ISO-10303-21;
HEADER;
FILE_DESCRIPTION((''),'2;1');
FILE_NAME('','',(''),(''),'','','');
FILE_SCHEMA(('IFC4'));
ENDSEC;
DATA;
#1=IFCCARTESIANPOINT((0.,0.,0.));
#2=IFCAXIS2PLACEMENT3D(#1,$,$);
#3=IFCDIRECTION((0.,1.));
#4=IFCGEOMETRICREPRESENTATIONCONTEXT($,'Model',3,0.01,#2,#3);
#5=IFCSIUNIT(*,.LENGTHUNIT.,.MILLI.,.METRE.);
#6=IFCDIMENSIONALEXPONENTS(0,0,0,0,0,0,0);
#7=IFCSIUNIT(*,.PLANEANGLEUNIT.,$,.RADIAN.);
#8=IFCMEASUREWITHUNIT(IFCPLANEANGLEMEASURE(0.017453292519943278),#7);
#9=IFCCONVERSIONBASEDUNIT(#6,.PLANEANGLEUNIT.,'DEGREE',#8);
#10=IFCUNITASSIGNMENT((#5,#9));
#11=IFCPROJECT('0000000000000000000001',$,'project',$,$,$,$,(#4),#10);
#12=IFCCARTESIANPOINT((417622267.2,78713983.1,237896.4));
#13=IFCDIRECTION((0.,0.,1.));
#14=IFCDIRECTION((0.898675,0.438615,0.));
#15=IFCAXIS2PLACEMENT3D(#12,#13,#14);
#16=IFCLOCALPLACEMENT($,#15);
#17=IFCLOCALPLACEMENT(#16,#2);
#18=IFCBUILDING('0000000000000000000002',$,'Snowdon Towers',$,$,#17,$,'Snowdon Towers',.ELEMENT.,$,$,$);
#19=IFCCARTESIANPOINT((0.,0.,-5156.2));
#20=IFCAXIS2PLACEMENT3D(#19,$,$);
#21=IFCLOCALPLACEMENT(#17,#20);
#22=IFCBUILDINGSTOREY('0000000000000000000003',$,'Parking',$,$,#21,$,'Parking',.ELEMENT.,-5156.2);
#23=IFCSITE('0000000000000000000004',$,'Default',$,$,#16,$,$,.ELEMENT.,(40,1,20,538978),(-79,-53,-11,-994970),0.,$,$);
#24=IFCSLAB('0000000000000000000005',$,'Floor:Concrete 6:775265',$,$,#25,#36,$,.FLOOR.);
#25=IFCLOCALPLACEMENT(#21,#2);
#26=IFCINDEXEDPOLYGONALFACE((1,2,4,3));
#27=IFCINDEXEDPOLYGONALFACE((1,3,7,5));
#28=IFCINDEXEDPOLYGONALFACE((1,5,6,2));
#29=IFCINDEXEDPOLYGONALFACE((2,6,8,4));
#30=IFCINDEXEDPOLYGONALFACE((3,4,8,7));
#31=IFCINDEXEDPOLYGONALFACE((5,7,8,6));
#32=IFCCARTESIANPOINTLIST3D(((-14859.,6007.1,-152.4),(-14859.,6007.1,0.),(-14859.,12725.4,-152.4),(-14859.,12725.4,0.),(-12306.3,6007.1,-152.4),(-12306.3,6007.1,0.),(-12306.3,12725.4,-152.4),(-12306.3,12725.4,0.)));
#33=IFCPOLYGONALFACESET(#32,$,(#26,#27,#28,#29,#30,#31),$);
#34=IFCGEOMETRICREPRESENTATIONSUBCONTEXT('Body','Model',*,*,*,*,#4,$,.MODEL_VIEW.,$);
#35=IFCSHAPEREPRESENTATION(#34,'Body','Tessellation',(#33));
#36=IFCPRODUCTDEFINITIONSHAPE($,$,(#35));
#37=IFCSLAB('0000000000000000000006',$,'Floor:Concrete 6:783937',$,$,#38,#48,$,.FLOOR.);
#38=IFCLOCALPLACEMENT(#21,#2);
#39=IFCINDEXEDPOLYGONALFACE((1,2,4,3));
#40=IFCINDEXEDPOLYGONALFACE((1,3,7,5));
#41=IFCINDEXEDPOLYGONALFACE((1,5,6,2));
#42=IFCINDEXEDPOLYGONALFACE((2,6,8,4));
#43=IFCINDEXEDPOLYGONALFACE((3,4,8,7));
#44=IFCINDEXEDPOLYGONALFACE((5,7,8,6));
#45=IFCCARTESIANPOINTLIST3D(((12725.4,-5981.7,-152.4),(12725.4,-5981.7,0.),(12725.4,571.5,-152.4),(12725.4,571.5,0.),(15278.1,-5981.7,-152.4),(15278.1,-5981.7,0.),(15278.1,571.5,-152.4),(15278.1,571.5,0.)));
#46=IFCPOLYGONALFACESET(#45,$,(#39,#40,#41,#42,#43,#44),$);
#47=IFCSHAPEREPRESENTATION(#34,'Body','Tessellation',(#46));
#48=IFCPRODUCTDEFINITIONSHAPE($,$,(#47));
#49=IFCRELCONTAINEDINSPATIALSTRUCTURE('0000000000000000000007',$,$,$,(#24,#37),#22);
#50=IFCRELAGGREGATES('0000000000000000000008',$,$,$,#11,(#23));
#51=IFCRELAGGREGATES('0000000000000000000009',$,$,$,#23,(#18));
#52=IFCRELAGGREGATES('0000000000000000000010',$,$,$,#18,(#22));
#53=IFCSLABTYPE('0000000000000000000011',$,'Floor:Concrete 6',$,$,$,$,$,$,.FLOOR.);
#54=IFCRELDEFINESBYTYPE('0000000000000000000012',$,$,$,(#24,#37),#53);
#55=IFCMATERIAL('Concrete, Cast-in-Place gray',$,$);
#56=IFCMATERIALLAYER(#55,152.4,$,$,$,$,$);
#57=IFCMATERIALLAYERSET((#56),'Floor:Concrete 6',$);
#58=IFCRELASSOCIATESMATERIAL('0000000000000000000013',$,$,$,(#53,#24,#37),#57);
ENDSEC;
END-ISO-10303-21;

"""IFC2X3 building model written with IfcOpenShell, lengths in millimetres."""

from ifc_helpers import new_model, entity, si_unit, converted_unit, direction, frame, frame_2d, origin, origin_2d_with_axis, place, context, subcontext, project, spatial, rectangle, extrude, material, layer, layer_set, layer_usage, type_object, element, save


model = new_model("IFC2X3")

# Units and contexts
model_context = context("Model", 3, precision=0.01, world=origin(), true_north=direction((0.0, 1.0)))
body_context = subcontext(model_context, "Body", "Model", "MODEL_VIEW")
ifc_project = project(units=[si_unit("LENGTHUNIT", "METRE", prefix="MILLI"), converted_unit("PLANEANGLEUNIT", "DEGREE", entity("IfcPlaneAngleMeasure", 0.017453292519943278), si_unit("PLANEANGLEUNIT", "RADIAN"), dimensions=[0, 0, 0, 0, 0, 0, 0])], contexts=[model_context])

# Site, building, storey
site_placement = place(None, frame((417622267.2, 78713983.1, 237896.4), z_axis=(0.0, 0.0, 1.0), x_axis=(0.898675, 0.438615, 0.0)))
site = spatial("IfcSite", under=ifc_project, at=site_placement, Name="Default", CompositionType="ELEMENT", RefLatitude=(40, 1, 20, 538978), RefLongitude=(-79, -53, -11, -994970), RefElevation=0.0)
building_placement = place(site_placement, origin())
building = spatial("IfcBuilding", under=site, at=building_placement, Name="Snowdon Towers", LongName="Snowdon Towers", CompositionType="ELEMENT")
storey_placement = place(building_placement, frame((0.0, 0.0, -5156.2)))
storey = spatial("IfcBuildingStorey", under=building, at=storey_placement, Name="Parking", LongName="Parking", CompositionType="ELEMENT", Elevation=-5156.2)

# Shared definitions
ifc_material = material(Name="Concrete, Cast-in-Place gray")

# Shared definitions
ifc_layer = layer(ifc_material, 152.4)
ifc_layer_set = layer_set([ifc_layer], Name="Floor:Concrete 6")
slab_type_1 = type_object("IfcSlabType", Name="Floor:Concrete 6", PredefinedType="FLOOR", material=ifc_layer_set)

# Slabs
ifc_layer_usage_1 = layer_usage(ifc_layer_set, "AXIS3", "POSITIVE", 0.0)
slab_1_placement = place(storey_placement, origin())
element("IfcSlab", 1, at=slab_1_placement, inside=storey, type_object=slab_type_1, material=ifc_layer_usage_1, Name="Floor:Concrete 6:775265", PredefinedType="FLOOR", context=body_context, shape_type="SweptSolid", body=[
    extrude(rectangle(XDim=6718.3, YDim=2552.7, at=frame_2d((0.0, 0.0), x_axis=(1.0, 0.0))), frame((-13582.6, 9366.3, 0.0), z_axis=(0.0, 0.0, -1.0), x_axis=(0.0, 1.0, 0.0)), (0.0, 0.0, 1.0), 152.4),
])
ifc_layer_usage_2 = layer_usage(ifc_layer_set, "AXIS3", "POSITIVE", 0.0)
slab_2_placement = place(storey_placement, origin())
element("IfcSlab", 2, at=slab_2_placement, inside=storey, type_object=slab_type_1, material=ifc_layer_usage_2, Name="Floor:Concrete 6:783937", PredefinedType="FLOOR", context=body_context, shape_type="SweptSolid", body=[
    extrude(rectangle(XDim=6553.2, YDim=2552.7, at=origin_2d_with_axis()), frame((14001.8, -2705.1, 0.0), z_axis=(0.0, 0.0, -1.0), x_axis=(0.0, 1.0, 0.0)), (0.0, 0.0, 1.0), 152.4),
])

save(model, "model.ifc")
